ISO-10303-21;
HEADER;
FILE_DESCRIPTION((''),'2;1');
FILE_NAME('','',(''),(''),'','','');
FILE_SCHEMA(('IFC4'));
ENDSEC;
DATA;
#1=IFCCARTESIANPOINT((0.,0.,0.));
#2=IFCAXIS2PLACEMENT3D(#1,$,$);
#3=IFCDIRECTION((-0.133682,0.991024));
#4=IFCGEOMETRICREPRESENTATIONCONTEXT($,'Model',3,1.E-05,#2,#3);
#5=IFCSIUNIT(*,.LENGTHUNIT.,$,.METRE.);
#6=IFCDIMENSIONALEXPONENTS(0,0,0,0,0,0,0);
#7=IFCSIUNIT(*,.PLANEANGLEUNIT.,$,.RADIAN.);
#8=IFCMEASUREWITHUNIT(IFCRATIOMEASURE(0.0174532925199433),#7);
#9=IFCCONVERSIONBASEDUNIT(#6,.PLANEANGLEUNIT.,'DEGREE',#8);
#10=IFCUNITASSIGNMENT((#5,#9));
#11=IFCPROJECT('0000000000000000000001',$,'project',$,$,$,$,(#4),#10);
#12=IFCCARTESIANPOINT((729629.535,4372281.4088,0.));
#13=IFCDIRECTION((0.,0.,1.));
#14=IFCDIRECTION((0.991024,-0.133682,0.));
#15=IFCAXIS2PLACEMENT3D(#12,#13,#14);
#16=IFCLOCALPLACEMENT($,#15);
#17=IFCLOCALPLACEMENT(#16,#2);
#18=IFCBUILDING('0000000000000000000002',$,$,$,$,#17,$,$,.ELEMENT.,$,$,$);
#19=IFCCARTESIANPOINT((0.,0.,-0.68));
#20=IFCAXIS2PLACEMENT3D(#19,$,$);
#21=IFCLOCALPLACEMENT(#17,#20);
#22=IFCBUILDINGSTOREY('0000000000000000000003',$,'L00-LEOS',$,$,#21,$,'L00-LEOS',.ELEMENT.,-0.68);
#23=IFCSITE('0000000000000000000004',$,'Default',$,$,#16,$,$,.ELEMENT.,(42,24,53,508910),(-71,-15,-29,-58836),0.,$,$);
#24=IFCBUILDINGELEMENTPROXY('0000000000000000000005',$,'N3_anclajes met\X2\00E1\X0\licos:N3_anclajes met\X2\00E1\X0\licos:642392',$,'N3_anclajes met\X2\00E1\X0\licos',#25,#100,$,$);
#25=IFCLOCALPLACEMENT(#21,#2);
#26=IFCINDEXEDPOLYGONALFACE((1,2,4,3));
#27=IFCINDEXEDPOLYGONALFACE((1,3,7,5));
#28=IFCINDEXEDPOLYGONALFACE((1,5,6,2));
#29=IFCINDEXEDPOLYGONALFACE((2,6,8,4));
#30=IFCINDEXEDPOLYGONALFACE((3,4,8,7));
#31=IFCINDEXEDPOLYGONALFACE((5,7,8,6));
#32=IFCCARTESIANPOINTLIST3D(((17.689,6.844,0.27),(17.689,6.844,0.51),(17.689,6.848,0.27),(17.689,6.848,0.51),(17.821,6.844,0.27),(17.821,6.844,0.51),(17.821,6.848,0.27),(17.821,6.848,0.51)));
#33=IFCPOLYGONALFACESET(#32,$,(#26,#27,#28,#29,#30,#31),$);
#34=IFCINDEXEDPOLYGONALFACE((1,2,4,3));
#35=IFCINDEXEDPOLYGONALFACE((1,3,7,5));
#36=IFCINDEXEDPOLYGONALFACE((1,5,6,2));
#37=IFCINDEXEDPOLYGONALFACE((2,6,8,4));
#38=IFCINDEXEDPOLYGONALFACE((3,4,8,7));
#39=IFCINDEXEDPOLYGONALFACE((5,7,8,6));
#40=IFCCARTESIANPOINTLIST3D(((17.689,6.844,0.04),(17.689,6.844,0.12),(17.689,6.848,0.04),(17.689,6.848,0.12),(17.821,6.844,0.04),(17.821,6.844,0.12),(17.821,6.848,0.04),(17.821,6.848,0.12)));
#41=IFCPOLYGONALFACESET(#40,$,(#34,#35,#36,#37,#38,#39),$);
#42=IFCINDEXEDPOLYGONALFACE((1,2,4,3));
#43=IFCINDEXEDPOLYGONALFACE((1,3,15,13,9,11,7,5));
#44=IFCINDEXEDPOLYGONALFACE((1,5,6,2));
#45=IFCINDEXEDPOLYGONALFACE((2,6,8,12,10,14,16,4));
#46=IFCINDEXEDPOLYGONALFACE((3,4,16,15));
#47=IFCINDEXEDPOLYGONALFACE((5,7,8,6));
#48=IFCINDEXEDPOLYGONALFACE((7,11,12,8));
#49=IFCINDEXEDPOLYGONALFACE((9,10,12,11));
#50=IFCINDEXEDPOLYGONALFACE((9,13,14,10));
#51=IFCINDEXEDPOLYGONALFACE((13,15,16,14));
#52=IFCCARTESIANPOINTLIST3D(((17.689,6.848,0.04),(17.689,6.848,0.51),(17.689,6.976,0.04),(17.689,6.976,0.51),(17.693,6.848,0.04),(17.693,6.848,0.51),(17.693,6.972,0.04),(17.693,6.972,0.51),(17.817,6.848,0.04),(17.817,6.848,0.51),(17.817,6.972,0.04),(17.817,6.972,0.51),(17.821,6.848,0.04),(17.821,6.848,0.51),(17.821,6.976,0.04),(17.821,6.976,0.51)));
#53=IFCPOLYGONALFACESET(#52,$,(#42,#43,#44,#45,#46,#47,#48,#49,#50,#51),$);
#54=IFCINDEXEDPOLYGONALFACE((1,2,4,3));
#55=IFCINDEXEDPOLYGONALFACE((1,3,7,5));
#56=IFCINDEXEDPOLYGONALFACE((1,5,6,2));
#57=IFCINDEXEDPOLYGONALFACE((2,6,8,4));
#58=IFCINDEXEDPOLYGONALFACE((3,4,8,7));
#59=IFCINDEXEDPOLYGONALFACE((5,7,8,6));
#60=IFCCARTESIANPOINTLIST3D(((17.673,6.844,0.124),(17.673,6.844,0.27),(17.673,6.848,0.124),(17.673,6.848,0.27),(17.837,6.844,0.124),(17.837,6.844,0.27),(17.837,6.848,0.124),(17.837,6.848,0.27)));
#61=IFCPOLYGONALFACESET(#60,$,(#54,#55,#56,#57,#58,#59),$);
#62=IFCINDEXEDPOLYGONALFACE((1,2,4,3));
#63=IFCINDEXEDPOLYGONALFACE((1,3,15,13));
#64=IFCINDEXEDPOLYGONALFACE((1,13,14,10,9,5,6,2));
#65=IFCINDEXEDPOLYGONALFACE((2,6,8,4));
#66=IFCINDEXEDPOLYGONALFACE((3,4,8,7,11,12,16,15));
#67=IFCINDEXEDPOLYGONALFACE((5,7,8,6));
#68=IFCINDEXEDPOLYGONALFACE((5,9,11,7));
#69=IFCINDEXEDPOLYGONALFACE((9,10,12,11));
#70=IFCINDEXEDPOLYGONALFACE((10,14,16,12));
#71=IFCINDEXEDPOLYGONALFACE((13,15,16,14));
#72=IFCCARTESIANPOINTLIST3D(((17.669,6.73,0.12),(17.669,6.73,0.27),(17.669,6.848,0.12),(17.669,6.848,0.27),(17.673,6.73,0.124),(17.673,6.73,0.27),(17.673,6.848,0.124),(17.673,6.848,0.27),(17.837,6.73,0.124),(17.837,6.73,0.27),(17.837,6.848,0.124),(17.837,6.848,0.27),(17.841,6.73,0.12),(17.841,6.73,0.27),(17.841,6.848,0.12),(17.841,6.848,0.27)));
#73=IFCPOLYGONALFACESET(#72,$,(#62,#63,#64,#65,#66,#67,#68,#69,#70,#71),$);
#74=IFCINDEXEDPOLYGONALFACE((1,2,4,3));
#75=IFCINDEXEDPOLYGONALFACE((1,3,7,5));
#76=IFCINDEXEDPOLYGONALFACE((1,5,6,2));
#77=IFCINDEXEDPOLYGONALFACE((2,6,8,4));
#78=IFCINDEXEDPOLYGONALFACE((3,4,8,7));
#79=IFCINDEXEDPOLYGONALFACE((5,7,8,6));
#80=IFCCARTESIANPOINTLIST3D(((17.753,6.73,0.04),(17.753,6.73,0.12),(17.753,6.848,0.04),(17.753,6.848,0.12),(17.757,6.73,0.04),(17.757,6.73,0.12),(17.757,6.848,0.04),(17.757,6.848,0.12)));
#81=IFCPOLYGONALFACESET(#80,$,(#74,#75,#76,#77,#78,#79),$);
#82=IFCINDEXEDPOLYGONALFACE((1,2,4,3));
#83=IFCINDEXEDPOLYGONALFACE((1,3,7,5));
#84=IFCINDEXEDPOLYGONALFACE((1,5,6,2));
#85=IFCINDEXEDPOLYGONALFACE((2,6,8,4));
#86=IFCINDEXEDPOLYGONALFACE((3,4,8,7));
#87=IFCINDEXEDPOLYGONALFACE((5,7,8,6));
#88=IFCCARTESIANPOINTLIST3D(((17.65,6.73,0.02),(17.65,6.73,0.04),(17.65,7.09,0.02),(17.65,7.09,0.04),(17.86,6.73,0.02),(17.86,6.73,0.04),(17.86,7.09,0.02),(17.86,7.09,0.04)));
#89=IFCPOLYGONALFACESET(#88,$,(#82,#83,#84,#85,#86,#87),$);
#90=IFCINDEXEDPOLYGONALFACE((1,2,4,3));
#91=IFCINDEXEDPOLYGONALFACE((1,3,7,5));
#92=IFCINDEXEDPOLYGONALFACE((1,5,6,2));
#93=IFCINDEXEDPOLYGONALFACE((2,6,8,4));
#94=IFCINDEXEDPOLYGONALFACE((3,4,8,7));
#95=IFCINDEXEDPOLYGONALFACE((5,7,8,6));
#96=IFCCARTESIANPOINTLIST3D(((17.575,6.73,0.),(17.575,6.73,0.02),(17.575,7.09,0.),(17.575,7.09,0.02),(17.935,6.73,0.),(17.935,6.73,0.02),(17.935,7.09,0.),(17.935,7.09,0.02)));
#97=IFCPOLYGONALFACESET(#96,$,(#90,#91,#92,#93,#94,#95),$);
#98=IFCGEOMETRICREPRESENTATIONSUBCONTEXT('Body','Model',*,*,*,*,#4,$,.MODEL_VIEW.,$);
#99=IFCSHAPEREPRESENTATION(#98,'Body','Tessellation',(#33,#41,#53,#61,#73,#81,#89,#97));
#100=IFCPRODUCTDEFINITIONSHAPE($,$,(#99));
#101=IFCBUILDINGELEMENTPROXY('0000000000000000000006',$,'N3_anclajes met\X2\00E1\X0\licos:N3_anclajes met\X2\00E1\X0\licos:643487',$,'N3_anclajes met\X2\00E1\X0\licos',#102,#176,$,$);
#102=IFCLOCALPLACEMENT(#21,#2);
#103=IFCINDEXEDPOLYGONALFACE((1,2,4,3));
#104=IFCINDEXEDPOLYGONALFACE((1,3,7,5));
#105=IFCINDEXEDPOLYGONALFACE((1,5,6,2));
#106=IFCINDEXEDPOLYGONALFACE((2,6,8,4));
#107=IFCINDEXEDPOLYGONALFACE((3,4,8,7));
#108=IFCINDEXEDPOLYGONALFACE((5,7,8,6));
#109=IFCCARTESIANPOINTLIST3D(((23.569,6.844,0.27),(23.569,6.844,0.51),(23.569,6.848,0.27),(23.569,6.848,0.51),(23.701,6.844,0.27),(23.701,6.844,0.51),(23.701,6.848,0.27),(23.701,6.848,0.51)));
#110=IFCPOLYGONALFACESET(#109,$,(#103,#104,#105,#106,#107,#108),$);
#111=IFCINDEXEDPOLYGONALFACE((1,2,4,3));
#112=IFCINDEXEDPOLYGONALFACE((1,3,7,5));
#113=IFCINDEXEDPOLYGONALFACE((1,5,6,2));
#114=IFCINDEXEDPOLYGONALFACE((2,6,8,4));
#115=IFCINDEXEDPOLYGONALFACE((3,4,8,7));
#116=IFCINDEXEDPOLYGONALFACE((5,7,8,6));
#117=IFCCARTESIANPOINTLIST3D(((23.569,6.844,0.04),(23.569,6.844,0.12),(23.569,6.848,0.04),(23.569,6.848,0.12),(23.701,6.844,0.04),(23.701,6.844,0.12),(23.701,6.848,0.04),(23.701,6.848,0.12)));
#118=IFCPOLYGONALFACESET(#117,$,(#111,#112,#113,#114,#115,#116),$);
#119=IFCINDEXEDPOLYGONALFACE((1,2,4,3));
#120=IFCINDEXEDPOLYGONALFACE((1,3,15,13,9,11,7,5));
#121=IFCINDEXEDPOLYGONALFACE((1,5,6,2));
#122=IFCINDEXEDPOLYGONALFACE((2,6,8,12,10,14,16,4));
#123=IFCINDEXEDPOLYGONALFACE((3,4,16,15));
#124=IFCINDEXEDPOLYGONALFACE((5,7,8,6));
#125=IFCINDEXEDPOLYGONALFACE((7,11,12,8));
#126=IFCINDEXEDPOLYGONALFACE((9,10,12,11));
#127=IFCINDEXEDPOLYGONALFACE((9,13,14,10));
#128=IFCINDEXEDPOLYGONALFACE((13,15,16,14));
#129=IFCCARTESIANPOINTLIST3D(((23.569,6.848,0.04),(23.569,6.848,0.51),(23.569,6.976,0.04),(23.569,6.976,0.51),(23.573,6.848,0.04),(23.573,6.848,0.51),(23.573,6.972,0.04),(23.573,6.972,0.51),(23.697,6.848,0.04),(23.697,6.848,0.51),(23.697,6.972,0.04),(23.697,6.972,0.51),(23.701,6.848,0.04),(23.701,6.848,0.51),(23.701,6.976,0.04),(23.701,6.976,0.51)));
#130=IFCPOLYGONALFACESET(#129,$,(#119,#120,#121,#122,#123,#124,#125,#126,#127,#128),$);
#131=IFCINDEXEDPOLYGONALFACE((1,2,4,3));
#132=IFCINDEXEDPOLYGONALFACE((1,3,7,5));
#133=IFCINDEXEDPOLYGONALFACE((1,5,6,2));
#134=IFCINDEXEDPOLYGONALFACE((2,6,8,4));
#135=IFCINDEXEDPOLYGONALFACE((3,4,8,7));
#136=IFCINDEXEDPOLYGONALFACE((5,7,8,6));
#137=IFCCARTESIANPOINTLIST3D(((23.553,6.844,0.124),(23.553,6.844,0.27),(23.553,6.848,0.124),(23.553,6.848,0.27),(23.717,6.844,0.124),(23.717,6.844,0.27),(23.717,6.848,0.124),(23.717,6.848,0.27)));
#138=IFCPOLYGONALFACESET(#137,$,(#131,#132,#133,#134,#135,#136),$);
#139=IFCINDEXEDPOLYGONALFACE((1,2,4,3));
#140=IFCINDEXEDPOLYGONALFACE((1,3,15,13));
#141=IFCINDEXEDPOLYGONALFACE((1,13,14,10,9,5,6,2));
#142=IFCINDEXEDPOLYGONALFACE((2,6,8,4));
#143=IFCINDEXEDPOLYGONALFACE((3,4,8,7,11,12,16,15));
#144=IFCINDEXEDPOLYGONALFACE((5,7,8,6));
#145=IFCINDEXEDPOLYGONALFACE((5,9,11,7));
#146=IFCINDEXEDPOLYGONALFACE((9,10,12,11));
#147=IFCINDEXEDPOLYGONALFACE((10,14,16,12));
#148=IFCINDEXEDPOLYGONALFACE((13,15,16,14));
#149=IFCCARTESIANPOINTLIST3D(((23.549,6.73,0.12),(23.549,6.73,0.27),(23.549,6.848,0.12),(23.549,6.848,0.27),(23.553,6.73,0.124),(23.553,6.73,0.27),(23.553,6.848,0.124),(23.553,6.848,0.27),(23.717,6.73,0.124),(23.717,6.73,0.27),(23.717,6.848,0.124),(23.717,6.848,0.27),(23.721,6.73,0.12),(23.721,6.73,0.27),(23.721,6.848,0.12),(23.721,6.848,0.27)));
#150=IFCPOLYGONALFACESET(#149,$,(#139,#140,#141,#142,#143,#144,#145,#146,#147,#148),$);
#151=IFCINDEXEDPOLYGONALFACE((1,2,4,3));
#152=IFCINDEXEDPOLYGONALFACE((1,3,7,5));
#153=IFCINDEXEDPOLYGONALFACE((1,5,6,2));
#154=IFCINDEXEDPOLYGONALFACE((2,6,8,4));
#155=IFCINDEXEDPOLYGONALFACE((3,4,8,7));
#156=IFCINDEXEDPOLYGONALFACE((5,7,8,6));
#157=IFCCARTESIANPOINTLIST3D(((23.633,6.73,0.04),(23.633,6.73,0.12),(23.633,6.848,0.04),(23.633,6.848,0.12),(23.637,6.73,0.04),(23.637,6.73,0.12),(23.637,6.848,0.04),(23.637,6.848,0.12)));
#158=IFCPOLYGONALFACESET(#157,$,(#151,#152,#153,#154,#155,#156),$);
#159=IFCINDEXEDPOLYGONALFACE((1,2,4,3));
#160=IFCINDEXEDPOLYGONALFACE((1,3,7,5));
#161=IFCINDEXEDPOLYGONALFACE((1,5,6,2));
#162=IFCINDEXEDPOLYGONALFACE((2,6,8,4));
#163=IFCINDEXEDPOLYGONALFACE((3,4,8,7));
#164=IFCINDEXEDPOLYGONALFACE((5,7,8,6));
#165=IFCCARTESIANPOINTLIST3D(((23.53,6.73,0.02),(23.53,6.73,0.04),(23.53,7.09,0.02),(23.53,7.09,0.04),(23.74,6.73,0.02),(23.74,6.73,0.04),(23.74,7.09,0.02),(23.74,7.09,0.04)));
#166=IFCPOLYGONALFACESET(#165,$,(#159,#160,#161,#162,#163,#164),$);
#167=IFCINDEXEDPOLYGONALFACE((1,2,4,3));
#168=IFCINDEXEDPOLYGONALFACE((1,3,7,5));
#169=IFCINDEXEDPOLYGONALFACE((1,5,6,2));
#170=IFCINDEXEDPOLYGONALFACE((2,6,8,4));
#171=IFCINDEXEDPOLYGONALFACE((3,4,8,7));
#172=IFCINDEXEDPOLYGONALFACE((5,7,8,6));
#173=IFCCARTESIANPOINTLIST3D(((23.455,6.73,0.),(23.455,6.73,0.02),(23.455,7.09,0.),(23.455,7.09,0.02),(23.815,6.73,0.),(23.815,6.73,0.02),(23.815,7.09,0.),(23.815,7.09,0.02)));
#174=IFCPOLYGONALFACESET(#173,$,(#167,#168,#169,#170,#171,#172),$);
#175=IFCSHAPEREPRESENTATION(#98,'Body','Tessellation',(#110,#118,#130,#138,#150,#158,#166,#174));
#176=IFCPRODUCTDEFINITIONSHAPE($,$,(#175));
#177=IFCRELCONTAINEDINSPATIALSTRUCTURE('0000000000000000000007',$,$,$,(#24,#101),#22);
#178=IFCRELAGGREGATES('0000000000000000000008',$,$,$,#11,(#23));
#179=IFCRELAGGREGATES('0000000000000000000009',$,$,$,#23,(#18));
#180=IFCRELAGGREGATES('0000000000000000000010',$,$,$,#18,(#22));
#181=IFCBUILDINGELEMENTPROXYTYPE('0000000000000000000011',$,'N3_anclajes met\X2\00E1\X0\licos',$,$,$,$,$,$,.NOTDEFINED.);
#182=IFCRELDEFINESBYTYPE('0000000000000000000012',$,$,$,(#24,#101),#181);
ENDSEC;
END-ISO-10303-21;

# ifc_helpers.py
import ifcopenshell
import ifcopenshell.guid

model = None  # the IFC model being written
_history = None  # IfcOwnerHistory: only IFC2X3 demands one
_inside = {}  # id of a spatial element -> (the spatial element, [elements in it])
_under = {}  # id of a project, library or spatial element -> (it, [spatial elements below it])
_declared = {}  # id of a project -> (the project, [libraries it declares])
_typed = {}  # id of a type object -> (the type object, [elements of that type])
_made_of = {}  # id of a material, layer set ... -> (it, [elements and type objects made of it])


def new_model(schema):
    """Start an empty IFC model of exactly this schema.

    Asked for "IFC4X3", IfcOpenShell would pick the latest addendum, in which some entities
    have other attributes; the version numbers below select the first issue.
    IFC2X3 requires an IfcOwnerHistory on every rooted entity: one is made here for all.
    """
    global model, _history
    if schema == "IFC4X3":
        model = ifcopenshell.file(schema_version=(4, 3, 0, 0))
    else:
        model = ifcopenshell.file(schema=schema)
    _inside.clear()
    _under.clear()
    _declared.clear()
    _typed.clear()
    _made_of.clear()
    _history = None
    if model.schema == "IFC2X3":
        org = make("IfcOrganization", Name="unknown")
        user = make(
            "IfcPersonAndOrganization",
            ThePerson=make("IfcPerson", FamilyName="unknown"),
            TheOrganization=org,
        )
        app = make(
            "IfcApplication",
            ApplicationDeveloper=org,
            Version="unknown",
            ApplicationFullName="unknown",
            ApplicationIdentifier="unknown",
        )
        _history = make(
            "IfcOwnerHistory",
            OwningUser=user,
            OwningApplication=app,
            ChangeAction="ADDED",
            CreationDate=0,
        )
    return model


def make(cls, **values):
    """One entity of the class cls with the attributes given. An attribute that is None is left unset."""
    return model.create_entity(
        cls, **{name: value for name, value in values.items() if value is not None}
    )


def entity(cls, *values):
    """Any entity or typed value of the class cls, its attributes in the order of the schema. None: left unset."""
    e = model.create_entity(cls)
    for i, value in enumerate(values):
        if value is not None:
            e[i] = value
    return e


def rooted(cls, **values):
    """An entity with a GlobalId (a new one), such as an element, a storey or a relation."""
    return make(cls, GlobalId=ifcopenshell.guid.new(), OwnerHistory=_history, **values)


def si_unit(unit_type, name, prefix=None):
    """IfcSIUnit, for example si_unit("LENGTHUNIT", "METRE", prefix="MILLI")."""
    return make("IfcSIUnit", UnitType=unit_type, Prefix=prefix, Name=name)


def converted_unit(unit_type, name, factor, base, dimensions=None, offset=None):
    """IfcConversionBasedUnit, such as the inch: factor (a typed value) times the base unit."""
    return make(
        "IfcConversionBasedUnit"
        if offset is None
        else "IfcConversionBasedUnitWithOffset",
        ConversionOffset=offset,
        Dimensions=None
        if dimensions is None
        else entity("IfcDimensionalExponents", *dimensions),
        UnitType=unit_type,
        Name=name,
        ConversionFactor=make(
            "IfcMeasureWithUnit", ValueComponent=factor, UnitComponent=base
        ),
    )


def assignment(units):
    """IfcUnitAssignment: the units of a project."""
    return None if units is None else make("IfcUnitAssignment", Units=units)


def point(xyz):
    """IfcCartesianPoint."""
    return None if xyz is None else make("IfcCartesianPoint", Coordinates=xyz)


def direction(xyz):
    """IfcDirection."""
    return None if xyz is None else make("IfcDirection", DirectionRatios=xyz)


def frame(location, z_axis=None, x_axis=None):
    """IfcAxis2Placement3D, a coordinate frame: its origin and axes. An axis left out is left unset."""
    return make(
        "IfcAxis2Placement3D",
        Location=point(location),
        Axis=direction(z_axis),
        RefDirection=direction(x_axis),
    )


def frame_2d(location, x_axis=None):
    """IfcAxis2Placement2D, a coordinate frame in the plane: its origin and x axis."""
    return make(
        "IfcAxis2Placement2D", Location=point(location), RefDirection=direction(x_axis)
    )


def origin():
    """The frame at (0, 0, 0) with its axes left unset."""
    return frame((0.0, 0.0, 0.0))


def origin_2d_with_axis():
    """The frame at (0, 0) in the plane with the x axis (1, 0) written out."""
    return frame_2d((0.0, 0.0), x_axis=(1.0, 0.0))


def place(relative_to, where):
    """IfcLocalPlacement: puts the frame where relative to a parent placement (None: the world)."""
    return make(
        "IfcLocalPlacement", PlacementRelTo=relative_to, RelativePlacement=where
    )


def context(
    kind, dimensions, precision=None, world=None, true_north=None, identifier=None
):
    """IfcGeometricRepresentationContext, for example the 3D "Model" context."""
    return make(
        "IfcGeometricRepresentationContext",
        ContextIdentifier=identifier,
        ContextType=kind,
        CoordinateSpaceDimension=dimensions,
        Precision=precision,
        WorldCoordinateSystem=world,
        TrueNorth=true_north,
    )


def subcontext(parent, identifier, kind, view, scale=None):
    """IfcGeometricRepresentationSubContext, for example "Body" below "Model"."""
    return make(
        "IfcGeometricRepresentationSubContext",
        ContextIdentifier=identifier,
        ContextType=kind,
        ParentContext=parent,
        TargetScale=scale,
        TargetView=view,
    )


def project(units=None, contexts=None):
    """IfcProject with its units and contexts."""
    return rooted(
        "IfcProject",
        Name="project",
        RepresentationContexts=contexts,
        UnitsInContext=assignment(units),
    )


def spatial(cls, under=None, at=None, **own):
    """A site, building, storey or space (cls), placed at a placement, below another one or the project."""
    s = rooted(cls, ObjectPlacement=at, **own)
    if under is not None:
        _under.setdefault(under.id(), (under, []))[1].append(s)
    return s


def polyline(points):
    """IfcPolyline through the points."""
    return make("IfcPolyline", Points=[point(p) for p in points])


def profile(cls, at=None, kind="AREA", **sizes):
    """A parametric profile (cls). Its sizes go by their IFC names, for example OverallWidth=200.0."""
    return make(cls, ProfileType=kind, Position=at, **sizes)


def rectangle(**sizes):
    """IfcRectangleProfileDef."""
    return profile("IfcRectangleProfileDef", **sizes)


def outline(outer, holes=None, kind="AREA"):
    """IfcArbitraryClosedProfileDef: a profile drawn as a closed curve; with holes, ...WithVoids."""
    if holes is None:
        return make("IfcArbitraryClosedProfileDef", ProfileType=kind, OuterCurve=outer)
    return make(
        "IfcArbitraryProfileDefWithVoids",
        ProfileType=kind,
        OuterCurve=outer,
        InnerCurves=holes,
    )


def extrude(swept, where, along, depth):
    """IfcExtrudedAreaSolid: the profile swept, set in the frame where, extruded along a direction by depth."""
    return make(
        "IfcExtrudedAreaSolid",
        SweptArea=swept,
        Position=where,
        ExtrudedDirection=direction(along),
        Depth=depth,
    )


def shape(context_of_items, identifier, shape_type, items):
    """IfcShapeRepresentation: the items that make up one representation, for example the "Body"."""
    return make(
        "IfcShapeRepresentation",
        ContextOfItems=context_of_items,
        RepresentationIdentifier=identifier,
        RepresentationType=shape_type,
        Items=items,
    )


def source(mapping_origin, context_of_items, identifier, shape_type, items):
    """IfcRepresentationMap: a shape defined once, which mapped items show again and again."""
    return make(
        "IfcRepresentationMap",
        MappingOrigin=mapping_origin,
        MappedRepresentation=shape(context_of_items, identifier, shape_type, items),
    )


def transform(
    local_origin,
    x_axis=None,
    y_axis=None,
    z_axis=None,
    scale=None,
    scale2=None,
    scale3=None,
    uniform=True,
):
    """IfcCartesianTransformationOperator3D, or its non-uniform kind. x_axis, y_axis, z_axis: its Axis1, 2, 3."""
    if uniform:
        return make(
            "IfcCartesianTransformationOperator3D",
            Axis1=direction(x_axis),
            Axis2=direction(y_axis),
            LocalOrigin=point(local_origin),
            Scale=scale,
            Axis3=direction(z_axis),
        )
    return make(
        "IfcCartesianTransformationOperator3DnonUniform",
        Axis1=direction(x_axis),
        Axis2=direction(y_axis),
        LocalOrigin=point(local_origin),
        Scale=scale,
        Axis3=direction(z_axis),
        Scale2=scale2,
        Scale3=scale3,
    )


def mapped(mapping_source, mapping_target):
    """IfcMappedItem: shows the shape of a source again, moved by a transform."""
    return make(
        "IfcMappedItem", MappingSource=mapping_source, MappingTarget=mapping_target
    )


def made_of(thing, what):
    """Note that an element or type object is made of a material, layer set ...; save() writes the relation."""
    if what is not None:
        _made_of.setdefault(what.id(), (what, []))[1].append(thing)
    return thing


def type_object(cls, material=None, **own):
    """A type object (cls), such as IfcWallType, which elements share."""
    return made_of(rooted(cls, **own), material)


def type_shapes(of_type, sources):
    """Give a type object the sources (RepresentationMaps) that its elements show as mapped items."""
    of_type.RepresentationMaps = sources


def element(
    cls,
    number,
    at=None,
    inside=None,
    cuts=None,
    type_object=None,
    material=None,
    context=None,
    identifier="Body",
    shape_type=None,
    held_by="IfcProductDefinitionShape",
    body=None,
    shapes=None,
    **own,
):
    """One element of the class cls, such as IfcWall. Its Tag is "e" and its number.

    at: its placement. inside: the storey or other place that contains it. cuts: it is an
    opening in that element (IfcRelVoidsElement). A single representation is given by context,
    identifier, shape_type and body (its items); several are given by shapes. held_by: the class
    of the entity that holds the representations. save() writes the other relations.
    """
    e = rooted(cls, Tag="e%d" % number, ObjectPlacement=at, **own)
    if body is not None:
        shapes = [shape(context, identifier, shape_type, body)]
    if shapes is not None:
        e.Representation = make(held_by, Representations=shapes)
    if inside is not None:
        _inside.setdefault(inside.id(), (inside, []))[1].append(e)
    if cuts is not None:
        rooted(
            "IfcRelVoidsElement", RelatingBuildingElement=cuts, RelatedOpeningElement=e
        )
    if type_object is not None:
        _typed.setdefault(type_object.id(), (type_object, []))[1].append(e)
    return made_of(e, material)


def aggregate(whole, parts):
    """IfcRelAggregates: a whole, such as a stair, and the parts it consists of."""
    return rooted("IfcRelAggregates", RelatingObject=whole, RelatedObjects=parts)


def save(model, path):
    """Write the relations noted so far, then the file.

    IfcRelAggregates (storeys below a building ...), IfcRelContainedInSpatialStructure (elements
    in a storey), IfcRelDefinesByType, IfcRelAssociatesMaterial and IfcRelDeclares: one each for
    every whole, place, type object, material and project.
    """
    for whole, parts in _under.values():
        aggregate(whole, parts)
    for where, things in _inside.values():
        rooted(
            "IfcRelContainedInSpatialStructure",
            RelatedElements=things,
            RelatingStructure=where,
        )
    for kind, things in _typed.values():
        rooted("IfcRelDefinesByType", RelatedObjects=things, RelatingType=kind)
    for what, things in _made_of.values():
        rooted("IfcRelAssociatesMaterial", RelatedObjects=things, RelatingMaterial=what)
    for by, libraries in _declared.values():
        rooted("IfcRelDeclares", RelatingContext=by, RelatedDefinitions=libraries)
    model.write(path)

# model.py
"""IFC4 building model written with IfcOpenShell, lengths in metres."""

from ifc_helpers import new_model, entity, si_unit, converted_unit, direction, frame, frame_2d, origin, origin_2d_with_axis, place, context, subcontext, project, spatial, polyline, rectangle, outline, extrude, source, transform, mapped, type_object, type_shapes, element, save


model = new_model("IFC4")

# Units and contexts
model_context = context("Model", 3, precision=1e-05, world=origin(), true_north=direction((-0.133682, 0.991024)))
body_context = subcontext(model_context, "Body", "Model", "MODEL_VIEW")
ifc_project = project(units=[si_unit("LENGTHUNIT", "METRE"), converted_unit("PLANEANGLEUNIT", "DEGREE", entity("IfcRatioMeasure", 0.0174532925199433), si_unit("PLANEANGLEUNIT", "RADIAN"), dimensions=[0, 0, 0, 0, 0, 0, 0])], contexts=[model_context])

# Site, building, storey
site_placement = place(None, frame((729629.535, 4372281.4088, 0.0), z_axis=(0.0, 0.0, 1.0), x_axis=(0.991024, -0.133682, 0.0)))
site = spatial("IfcSite", under=ifc_project, at=site_placement, Name="Default", CompositionType="ELEMENT", RefLatitude=(42, 24, 53, 508910), RefLongitude=(-71, -15, -29, -58836), RefElevation=0.0)
building_placement = place(site_placement, origin())
building = spatial("IfcBuilding", under=site, at=building_placement, CompositionType="ELEMENT")
storey_placement = place(building_placement, frame((0.0, 0.0, -0.68)))
storey = spatial("IfcBuildingStorey", under=building, at=storey_placement, Name="L00-LEOS", LongName="L00-LEOS", CompositionType="ELEMENT", Elevation=-0.68)

# Building element proxies
building_element_proxy_type_1 = type_object("IfcBuildingElementProxyType", Name="N3_anclajes metálicos")
shared_shape_1 = source(origin(), body_context, "Body", "SweptSolid", [
    extrude(rectangle(XDim=0.132, YDim=0.004, at=frame_2d((0.0, 0.0), x_axis=(1.0, 0.0))), frame((-0.064, 0.0, 0.27), z_axis=(0.0, 0.0, 1.0), x_axis=(0.0, 1.0, 0.0)), (0.0, 0.0, 1.0), 0.24),
    extrude(rectangle(XDim=0.132, YDim=0.004, at=frame_2d((0.0, 0.0), x_axis=(1.0, 0.0))), frame((-0.064, 0.0, 0.04), z_axis=(0.0, 0.0, 1.0), x_axis=(0.0, 1.0, 0.0)), (0.0, 0.0, 1.0), 0.08),
    extrude(outline(polyline([(-0.065, -0.066), (0.063, -0.066), (0.063, -0.062), (-0.061, -0.062), (-0.061, 0.062), (0.063, 0.062), (0.063, 0.066), (-0.065, 0.066), (-0.065, -0.066)])), frame((0.001, 0.0, 0.04), z_axis=(0.0, 0.0, 1.0), x_axis=(-1.0, 0.0, 0.0)), (0.0, 0.0, 1.0), 0.47),
    extrude(rectangle(XDim=0.164, YDim=0.004, at=frame_2d((0.0, 0.0), x_axis=(1.0, 0.0))), frame((-0.064, 0.0, 0.124), z_axis=(0.0, 0.0, 1.0), x_axis=(0.0, -1.0, 0.0)), (0.0, 0.0, 1.0), 0.146),
    extrude(outline(polyline([(-0.076, -0.086), (0.074, -0.086), (0.074, -0.082), (-0.072, -0.082), (-0.072, 0.082), (0.074, 0.082), (0.074, 0.086), (-0.076, 0.086), (-0.076, -0.086)])), frame((-0.18, 0.0, 0.196), z_axis=(1.0, 0.0, 0.0), x_axis=(0.0, 0.0, 1.0)), (0.0, 0.0, 1.0), 0.118),
    extrude(rectangle(XDim=0.004, YDim=0.118, at=origin_2d_with_axis()), frame((-0.121, 0.0, 0.04), z_axis=(0.0, 0.0, 1.0), x_axis=(0.0, -1.0, 0.0)), (0.0, 0.0, 1.0), 0.08),
    extrude(rectangle(XDim=0.36, YDim=0.21, at=frame_2d((0.0, 0.0), x_axis=(1.0, 0.0))), frame((0.0, 0.0, 0.02), z_axis=(0.0, 0.0, 1.0), x_axis=(-1.0, 0.0, 0.0)), (0.0, 0.0, 1.0), 0.02),
    extrude(rectangle(XDim=0.36, YDim=0.36, at=frame_2d((0.0, 0.0), x_axis=(1.0, 0.0))), frame((0.0, 0.0, 0.0), z_axis=(0.0, 0.0, 1.0), x_axis=(-1.0, 0.0, 0.0)), (0.0, 0.0, 1.0), 0.02),
])
type_shapes(building_element_proxy_type_1, [shared_shape_1])
for number, where, z_axis, x_axis, name in (
    (1, (17.755, 6.91, 0.0), (0.0, 0.0, 1.0), (0.0, 1.0, 0.0), "N3_anclajes metálicos:N3_anclajes metálicos:642392"),
    (2, (23.635, 6.91, 0.0), (0.0, 0.0, 1.0), (0.0, 1.0, 0.0), "N3_anclajes metálicos:N3_anclajes metálicos:643487"),
):
    element("IfcBuildingElementProxy", number, at=place(storey_placement, frame(where, z_axis=z_axis, x_axis=x_axis)), inside=storey, type_object=building_element_proxy_type_1, Name=name, ObjectType="N3_anclajes metálicos", context=body_context, shape_type="MappedRepresentation", body=[
        mapped(shared_shape_1, transform((0.0, 0.0, 0.0), scale=1.0)),
    ])

save(model, "model.ifc")
